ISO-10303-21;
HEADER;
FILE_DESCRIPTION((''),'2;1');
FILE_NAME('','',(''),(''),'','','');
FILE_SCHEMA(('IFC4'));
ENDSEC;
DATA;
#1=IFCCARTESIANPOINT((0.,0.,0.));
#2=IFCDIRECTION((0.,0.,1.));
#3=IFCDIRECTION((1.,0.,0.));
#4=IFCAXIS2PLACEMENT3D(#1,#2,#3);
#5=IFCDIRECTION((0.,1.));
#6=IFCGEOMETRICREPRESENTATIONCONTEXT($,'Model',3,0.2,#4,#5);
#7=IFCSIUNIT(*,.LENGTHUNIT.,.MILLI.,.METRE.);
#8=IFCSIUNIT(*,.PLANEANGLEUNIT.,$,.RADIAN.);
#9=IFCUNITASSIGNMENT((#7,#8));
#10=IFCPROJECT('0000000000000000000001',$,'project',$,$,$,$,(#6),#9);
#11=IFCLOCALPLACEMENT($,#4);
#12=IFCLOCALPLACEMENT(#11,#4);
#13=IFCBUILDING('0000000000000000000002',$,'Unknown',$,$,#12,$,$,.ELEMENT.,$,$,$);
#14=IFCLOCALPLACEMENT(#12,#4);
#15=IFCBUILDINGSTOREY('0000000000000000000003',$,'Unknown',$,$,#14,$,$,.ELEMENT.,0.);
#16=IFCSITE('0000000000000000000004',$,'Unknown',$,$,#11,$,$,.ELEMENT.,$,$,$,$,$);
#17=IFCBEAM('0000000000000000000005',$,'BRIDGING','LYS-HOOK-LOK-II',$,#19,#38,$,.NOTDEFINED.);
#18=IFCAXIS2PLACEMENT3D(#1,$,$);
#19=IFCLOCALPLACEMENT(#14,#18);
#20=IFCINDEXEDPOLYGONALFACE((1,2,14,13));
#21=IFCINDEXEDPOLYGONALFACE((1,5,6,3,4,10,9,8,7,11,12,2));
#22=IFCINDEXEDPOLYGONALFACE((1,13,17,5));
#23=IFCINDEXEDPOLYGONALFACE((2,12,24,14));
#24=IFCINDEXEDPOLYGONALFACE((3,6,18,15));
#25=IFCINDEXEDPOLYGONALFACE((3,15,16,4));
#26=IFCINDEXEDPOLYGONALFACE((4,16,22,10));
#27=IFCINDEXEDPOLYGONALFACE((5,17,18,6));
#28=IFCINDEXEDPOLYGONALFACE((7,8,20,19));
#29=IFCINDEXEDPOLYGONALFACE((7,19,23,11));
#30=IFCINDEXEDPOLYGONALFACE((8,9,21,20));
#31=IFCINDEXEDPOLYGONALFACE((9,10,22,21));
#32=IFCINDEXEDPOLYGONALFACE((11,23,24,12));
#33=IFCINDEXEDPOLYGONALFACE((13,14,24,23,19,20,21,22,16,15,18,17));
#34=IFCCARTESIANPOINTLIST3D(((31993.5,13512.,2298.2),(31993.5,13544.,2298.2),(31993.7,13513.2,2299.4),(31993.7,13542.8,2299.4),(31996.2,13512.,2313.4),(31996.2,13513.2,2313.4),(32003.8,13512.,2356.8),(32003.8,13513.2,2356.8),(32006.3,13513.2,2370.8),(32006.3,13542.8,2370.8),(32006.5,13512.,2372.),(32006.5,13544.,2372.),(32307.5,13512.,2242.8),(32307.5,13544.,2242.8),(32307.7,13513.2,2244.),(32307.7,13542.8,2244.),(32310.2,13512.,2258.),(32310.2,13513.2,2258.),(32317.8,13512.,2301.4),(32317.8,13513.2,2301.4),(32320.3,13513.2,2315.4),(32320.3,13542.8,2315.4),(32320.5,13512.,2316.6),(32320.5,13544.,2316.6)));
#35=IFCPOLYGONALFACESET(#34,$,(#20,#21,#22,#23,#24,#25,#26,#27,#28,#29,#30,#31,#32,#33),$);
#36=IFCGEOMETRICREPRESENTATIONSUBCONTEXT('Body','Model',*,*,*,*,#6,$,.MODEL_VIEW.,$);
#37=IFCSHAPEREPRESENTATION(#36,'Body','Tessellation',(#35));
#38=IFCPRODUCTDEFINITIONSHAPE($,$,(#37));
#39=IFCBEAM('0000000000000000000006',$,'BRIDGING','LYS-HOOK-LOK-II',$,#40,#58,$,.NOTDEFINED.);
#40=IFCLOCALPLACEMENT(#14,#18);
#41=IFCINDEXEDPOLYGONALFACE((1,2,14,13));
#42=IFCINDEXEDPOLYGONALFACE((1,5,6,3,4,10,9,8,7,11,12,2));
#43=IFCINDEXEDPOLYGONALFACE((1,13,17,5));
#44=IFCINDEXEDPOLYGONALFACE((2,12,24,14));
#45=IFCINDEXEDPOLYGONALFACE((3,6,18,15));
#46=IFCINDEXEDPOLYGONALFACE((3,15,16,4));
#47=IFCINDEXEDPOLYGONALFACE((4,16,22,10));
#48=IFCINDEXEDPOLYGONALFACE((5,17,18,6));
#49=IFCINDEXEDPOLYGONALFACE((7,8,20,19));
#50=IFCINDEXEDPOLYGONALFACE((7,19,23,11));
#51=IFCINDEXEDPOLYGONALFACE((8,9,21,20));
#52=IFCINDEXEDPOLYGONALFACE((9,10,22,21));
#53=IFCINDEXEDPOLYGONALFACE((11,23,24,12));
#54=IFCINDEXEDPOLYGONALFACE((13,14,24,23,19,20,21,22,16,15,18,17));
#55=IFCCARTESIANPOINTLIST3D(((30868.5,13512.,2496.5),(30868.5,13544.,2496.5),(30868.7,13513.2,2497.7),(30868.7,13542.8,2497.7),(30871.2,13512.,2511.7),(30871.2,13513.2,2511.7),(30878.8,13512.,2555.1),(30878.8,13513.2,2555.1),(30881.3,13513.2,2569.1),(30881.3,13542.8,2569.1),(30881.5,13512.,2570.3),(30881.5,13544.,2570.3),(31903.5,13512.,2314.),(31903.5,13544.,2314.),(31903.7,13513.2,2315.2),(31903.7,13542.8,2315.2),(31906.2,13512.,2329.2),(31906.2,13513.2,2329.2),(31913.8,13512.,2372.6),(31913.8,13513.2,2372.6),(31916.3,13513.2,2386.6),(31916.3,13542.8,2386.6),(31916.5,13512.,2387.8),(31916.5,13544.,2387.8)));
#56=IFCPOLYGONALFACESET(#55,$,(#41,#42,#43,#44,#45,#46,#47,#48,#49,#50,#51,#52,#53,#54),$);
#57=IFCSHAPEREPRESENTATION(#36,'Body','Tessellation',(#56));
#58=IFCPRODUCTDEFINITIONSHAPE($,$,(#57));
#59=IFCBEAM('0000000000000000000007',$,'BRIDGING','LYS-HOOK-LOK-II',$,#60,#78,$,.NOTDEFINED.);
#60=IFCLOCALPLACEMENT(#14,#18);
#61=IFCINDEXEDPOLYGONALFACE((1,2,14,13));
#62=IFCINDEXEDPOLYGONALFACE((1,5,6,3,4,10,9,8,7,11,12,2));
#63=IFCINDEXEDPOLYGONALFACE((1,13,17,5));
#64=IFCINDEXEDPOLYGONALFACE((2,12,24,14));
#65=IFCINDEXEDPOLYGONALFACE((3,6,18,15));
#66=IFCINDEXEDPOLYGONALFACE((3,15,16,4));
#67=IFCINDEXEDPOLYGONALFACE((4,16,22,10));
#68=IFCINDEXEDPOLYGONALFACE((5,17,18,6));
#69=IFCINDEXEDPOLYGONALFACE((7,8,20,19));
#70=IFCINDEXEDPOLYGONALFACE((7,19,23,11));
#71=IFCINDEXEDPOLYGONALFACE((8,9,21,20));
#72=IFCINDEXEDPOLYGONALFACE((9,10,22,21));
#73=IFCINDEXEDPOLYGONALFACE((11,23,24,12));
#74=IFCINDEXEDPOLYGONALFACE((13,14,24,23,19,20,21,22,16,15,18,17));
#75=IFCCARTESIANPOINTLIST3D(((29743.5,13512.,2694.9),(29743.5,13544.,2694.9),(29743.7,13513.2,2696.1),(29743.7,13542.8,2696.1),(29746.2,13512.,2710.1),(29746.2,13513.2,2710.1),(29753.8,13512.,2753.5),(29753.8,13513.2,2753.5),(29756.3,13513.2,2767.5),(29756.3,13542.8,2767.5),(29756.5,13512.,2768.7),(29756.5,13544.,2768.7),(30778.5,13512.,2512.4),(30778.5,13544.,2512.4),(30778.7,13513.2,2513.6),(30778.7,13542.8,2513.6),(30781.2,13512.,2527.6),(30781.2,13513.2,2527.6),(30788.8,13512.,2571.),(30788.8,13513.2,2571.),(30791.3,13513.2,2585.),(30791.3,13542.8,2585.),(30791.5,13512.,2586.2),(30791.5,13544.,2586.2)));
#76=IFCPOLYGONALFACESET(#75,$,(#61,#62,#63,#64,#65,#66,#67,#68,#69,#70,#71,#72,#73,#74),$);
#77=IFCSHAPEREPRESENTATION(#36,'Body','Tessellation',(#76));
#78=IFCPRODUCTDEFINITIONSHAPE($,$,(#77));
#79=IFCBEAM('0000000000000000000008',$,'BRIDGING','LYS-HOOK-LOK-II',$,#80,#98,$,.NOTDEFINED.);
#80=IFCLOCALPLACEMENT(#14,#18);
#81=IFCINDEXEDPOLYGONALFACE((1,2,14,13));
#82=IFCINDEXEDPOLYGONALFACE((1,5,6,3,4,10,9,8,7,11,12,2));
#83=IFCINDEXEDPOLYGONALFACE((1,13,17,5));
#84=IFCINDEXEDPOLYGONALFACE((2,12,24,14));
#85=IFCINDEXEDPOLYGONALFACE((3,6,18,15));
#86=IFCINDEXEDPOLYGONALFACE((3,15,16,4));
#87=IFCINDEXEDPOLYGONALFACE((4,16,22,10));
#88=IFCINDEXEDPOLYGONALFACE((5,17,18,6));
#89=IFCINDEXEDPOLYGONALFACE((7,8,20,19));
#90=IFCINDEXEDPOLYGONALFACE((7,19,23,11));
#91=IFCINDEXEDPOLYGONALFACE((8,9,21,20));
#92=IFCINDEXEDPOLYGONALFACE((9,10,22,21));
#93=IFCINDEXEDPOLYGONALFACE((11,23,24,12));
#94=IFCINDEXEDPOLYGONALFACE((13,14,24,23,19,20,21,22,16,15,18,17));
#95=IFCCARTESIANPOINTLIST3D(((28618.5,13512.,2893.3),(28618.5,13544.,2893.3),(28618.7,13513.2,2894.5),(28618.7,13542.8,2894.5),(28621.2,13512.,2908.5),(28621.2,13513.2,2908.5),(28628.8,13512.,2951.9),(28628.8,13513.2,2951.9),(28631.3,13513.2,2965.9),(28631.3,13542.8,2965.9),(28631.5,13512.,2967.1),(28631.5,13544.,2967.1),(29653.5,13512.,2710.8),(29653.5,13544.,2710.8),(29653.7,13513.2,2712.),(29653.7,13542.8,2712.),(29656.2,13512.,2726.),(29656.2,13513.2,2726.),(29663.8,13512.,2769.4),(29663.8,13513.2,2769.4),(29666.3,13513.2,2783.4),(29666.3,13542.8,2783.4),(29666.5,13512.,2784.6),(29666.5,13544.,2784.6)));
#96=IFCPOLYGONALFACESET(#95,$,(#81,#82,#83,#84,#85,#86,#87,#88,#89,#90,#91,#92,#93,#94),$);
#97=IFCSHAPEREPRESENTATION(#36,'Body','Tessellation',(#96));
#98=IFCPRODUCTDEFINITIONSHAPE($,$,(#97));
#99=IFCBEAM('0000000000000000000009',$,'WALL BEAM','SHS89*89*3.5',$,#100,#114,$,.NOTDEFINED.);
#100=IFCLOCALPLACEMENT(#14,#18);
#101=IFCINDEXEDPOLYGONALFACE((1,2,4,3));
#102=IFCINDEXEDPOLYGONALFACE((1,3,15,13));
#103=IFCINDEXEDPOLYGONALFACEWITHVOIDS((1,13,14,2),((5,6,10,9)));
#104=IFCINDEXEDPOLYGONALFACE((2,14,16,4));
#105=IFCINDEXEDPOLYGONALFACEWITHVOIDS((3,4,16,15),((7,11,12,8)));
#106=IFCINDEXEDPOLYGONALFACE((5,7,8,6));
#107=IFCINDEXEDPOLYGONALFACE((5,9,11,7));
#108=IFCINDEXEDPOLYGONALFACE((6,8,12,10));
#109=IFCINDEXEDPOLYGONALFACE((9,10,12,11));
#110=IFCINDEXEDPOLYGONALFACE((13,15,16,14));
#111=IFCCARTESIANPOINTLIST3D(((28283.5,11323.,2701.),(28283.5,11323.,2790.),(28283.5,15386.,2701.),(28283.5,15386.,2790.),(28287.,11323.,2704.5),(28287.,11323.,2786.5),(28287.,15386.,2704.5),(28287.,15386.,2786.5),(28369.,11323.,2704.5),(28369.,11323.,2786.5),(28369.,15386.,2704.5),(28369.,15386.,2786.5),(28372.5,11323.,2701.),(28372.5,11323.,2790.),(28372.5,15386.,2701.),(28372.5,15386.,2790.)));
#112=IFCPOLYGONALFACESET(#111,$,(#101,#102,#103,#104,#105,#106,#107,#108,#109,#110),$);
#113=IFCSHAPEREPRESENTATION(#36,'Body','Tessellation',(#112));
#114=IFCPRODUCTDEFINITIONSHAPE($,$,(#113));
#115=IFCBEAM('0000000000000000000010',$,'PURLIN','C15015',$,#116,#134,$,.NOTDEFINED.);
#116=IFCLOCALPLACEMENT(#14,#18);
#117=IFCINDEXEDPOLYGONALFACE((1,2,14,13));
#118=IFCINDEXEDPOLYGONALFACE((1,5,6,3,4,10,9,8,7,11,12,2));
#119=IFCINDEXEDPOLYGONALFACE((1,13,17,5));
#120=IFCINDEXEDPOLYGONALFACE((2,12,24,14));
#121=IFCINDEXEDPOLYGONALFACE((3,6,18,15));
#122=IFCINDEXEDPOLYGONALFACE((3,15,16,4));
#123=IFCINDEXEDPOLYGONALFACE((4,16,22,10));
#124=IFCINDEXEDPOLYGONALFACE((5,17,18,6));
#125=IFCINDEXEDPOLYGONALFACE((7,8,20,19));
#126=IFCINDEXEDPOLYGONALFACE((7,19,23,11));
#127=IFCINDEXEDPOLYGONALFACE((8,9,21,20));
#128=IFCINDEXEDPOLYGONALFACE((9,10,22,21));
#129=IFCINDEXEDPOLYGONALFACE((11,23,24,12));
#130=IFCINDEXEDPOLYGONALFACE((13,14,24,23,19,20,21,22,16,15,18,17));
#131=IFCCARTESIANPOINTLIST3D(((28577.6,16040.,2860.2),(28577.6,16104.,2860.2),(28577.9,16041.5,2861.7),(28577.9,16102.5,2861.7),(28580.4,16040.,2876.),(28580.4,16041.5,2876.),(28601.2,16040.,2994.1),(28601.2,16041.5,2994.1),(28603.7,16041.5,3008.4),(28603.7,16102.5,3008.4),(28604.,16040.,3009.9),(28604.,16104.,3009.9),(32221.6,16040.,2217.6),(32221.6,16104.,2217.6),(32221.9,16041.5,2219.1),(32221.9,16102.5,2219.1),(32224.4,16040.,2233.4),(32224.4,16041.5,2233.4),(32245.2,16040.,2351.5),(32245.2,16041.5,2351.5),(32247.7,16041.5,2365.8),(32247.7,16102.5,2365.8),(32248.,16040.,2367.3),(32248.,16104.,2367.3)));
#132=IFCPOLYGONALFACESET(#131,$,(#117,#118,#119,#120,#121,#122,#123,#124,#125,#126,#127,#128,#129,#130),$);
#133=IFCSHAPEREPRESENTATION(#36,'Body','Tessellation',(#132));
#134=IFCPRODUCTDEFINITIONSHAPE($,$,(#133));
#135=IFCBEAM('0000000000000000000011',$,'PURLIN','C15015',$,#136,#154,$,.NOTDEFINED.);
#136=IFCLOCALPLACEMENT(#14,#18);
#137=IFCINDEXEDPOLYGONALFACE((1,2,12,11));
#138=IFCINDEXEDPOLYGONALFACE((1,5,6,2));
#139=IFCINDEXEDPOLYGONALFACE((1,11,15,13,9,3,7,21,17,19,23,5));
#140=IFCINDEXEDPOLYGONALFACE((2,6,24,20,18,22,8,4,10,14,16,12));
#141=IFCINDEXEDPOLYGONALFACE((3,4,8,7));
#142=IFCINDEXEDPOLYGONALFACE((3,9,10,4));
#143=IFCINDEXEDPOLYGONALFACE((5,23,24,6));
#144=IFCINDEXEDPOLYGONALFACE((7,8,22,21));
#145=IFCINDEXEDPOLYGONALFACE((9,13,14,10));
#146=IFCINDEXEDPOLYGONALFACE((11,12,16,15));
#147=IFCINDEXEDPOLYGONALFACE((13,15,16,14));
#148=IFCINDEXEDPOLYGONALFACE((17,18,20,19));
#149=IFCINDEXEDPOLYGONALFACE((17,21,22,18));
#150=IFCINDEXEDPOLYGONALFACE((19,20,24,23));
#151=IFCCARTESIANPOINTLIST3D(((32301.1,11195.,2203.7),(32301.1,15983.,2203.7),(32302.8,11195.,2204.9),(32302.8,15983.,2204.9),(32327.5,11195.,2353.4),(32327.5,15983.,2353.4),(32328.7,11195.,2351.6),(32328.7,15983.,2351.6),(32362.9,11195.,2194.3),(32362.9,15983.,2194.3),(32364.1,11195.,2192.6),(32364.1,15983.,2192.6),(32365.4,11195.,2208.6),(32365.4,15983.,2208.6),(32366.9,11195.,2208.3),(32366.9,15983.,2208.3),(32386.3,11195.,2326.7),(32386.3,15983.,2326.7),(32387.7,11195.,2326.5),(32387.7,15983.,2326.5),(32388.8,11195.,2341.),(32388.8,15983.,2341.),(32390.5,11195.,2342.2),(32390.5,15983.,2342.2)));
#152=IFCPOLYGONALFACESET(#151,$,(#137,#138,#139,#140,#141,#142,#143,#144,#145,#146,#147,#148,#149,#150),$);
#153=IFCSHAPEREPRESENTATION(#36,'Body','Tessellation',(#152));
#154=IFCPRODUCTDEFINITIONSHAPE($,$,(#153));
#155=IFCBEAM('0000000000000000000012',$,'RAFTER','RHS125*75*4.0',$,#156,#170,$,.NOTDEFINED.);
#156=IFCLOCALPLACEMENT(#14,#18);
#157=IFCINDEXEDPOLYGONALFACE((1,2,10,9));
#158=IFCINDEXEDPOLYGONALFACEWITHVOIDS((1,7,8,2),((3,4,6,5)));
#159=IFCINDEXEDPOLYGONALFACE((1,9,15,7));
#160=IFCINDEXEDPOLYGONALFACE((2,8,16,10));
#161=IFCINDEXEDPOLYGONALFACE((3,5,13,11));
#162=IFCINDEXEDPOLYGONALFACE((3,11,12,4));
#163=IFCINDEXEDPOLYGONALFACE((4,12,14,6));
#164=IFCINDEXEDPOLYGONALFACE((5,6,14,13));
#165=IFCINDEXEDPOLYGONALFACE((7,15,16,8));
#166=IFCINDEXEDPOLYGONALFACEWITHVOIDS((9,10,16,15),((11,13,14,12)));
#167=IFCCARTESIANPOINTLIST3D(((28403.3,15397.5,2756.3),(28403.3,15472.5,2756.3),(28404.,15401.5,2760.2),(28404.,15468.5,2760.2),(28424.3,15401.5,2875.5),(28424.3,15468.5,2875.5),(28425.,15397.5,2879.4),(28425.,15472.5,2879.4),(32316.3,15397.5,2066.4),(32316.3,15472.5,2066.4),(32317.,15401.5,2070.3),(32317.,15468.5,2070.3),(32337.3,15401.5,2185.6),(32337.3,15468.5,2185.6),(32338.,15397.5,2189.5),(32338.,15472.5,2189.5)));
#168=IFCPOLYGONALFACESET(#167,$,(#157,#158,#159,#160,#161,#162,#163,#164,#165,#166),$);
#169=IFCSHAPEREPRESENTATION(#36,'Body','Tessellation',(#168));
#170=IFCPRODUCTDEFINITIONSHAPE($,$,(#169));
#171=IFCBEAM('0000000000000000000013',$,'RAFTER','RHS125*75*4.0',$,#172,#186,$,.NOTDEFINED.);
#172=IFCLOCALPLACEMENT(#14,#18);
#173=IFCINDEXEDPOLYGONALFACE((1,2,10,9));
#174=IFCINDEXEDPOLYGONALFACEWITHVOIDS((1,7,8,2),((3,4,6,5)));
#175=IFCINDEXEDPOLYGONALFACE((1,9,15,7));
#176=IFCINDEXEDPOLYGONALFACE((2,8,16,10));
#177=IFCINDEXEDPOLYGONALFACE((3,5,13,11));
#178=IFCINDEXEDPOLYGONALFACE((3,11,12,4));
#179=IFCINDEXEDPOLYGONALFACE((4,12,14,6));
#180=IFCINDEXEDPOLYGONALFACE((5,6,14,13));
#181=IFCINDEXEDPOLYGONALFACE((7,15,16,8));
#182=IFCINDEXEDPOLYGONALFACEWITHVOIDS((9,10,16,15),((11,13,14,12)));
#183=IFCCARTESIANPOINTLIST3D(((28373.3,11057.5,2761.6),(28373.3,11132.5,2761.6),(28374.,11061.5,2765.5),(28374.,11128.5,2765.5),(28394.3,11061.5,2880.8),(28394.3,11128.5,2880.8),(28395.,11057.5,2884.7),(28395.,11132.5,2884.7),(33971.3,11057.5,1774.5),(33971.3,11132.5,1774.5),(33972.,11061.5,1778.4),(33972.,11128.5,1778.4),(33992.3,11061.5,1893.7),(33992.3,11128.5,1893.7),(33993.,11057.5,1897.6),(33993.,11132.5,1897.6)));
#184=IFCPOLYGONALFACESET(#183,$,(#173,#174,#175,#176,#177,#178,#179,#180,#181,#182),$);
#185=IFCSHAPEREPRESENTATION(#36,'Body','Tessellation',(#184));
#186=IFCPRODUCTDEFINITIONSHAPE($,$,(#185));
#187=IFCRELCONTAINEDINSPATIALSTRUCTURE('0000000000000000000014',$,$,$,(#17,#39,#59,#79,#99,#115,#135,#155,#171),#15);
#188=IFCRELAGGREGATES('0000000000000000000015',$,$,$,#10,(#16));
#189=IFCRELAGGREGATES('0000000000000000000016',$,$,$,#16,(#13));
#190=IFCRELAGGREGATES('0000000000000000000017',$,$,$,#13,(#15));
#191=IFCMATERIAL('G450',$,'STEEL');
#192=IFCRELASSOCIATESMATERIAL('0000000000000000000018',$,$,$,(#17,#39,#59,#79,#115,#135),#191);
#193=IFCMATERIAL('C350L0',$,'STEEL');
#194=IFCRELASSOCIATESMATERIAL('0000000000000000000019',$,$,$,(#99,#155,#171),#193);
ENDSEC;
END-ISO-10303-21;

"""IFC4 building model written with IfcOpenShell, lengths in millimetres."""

from ifc_helpers import new_model, si_unit, direction, frame, origin_with_axes, place, context, subcontext, project, spatial, line, indexed_curve, outline, extrude, material, element, save


model = new_model("IFC4")

# Units and contexts
model_context = context("Model", 3, precision=0.2, world=origin_with_axes(), true_north=direction((0.0, 1.0)))
body_context = subcontext(model_context, "Body", "Model", "MODEL_VIEW")
ifc_project = project(units=[si_unit("LENGTHUNIT", "METRE", prefix="MILLI"), si_unit("PLANEANGLEUNIT", "RADIAN")], contexts=[model_context])

# Site, building, storey
site_placement = place(None, origin_with_axes())
site = spatial("IfcSite", under=ifc_project, at=site_placement, Name="Unknown", CompositionType="ELEMENT")
building_placement = place(site_placement, origin_with_axes())
building = spatial("IfcBuilding", under=site, at=building_placement, Name="Unknown", CompositionType="ELEMENT")
storey_placement = place(building_placement, origin_with_axes())
storey = spatial("IfcBuildingStorey", under=building, at=storey_placement, Name="Unknown", CompositionType="ELEMENT", Elevation=0.0)

# Beams
ifc_material_1 = material(Name="G450", Category="STEEL")
beam_1_placement = place(storey_placement, frame((32000.0, 13528.0, 2335.1), z_axis=(0.0, -1.0, 0.0), x_axis=(0.98479, 0.0, -0.17375)))
element("IfcBeam", 1, at=beam_1_placement, inside=storey, material=ifc_material_1, Name="BRIDGING", Description="LYS-HOOK-LOK-II", PredefinedType="NOTDEFINED", context=body_context, shape_type="SolidModel", body=[
    extrude(outline(indexed_curve([(16.0, -37.5), (16.0, -22.0), (14.8, -22.0), (14.8, -36.3), (-14.8, -36.3), (-14.8, 36.3), (14.8, 36.3), (14.8, 22.0), (16.0, 22.0), (16.0, 37.5), (-16.0, 37.5), (-16.0, -37.5)], segments=[line(1, 2, 3, 4, 5, 6, 7, 8, 9, 10, 11, 12, 1)])), frame((0.0, 0.0, 0.0), z_axis=(-1.0, 0.0, 0.0), x_axis=(0.0, 0.0, 1.0)), (0.0, 0.0, -1.0), 318.8),
])
for number, where, z_axis, x_axis, name in (
    (2, (30875.0, 13528.0, 2533.4), (0.0, -1.0, 0.0), (0.984807, 0.0, -0.17365), "BRIDGING"),
    (3, (29750.0, 13528.0, 2731.8), (0.0, -1.0, 0.0), (0.984807, 0.0, -0.17365), "BRIDGING"),
    (4, (28625.0, 13528.0, 2930.2), (0.0, -1.0, 0.0), (0.984807, 0.0, -0.17365), "BRIDGING"),
):
    element("IfcBeam", number, at=place(storey_placement, frame(where, z_axis=z_axis, x_axis=x_axis)), inside=storey, material=ifc_material_1, Name=name, Description="LYS-HOOK-LOK-II", PredefinedType="NOTDEFINED", context=body_context, shape_type="SolidModel", body=[
        extrude(outline(indexed_curve([(16.0, -37.5), (16.0, -22.0), (14.8, -22.0), (14.8, -36.3), (-14.8, -36.3), (-14.8, 36.3), (14.8, 36.3), (14.8, 22.0), (16.0, 22.0), (16.0, 37.5), (-16.0, 37.5), (-16.0, -37.5)], segments=[line(1, 2, 3, 4, 5, 6, 7, 8, 9, 10, 11, 12, 1)])), frame((0.0, 0.0, 0.0), z_axis=(-1.0, 0.0, 0.0), x_axis=(0.0, 0.0, 1.0)), (0.0, 0.0, -1.0), 1051.0),
    ])
ifc_material_2 = material(Name="C350L0", Category="STEEL")
beam_2_placement = place(storey_placement, frame((28328.0, 11323.0, 2745.5), z_axis=(0.0, 0.0, 1.0), x_axis=(0.0, 1.0, 0.0)))
element("IfcBeam", 5, at=beam_2_placement, inside=storey, material=ifc_material_2, Name="WALL BEAM", Description="SHS89*89*3.5", PredefinedType="NOTDEFINED", context=body_context, shape_type="SolidModel", body=[
    extrude(outline(indexed_curve([(-44.5, -44.5), (44.5, -44.5), (44.5, 44.5), (-44.5, 44.5)], segments=[line(1, 2, 3, 4, 1)]), holes=[indexed_curve([(-41.0, -41.0), (-41.0, 41.0), (41.0, 41.0), (41.0, -41.0)], segments=[line(1, 2, 3, 4, 1)])]), frame((0.0, 0.0, 0.0), z_axis=(-1.0, 0.0, 0.0), x_axis=(0.0, 0.0, 1.0)), (0.0, 0.0, -1.0), 4063.0),
])
beam_3_placement = place(storey_placement, frame((28590.8, 16072.0, 2935.1), z_axis=(0.0, -1.0, 0.0), x_axis=(0.984805, 0.0, -0.173665)))
element("IfcBeam", 6, at=beam_3_placement, inside=storey, material=ifc_material_1, Name="PURLIN", Description="C15015", PredefinedType="NOTDEFINED", context=body_context, shape_type="SolidModel", body=[
    extrude(outline(indexed_curve([(32.0, -76.0), (32.0, -60.0), (30.5, -60.0), (30.5, -74.5), (-30.5, -74.5), (-30.5, 74.5), (30.5, 74.5), (30.5, 60.0), (32.0, 60.0), (32.0, 76.0), (-32.0, 76.0), (-32.0, -76.0)], segments=[line(1, 2, 3, 4, 5, 6, 7, 8, 9, 10, 11, 12, 1)])), frame((0.0, 0.0, 0.0), z_axis=(-1.0, 0.0, 0.0), x_axis=(0.0, 0.0, 1.0)), (0.0, 0.0, -1.0), 3700.2),
])
beam_4_placement = place(storey_placement, frame((32345.8, 11195.0, 2273.0), z_axis=(0.984808, 0.0, -0.173648), x_axis=(0.0, 1.0, 0.0)))
element("IfcBeam", 7, at=beam_4_placement, inside=storey, material=ifc_material_1, Name="PURLIN", Description="C15015", PredefinedType="NOTDEFINED", context=body_context, shape_type="SolidModel", body=[
    extrude(outline(indexed_curve([(32.0, -76.0), (32.0, -60.0), (30.5, -60.0), (30.5, -74.5), (-30.5, -74.5), (-30.5, 74.5), (30.5, 74.5), (30.5, 60.0), (32.0, 60.0), (32.0, 76.0), (-32.0, 76.0), (-32.0, -76.0)], segments=[line(1, 2, 3, 4, 5, 6, 7, 8, 9, 10, 11, 12, 1)])), frame((0.0, 0.0, 0.0), z_axis=(-1.0, 0.0, 0.0), x_axis=(0.0, 0.0, 1.0)), (0.0, 0.0, -1.0), 4788.0),
])
beam_5_placement = place(storey_placement, frame((28414.1, 15435.0, 2817.8), z_axis=(0.0, -1.0, 0.0), x_axis=(0.984811, 0.0, -0.173632)))
element("IfcBeam", 8, at=beam_5_placement, inside=storey, material=ifc_material_2, Name="RAFTER", Description="RHS125*75*4.0", PredefinedType="NOTDEFINED", context=body_context, shape_type="SolidModel", body=[
    extrude(outline(indexed_curve([(-37.5, -62.5), (37.5, -62.5), (37.5, 62.5), (-37.5, 62.5)], segments=[line(1, 2, 3, 4, 1)]), holes=[indexed_curve([(-33.5, -58.5), (-33.5, 58.5), (33.5, 58.5), (33.5, -58.5)], segments=[line(1, 2, 3, 4, 1)])]), frame((0.0, 0.0, 0.0), z_axis=(-1.0, 0.0, 0.0), x_axis=(0.0, 0.0, 1.0)), (0.0, 0.0, -1.0), 3973.4),
])
beam_6_placement = place(storey_placement, frame((28384.1, 11095.0, 2823.1), z_axis=(0.0, -1.0, 0.0), x_axis=(0.984807, 0.0, -0.173652)))
element("IfcBeam", 9, at=beam_6_placement, inside=storey, material=ifc_material_2, Name="RAFTER", Description="RHS125*75*4.0", PredefinedType="NOTDEFINED", context=body_context, shape_type="SolidModel", body=[
    extrude(outline(indexed_curve([(-37.5, -62.5), (37.5, -62.5), (37.5, 62.5), (-37.5, 62.5)], segments=[line(1, 2, 3, 4, 1)]), holes=[indexed_curve([(-33.5, -58.5), (-33.5, 58.5), (33.5, 58.5), (33.5, -58.5)], segments=[line(1, 2, 3, 4, 1)])]), frame((0.0, 0.0, 0.0), z_axis=(-1.0, 0.0, 0.0), x_axis=(0.0, 0.0, 1.0)), (0.0, 0.0, -1.0), 5684.4),
])

save(model, "model.ifc")
